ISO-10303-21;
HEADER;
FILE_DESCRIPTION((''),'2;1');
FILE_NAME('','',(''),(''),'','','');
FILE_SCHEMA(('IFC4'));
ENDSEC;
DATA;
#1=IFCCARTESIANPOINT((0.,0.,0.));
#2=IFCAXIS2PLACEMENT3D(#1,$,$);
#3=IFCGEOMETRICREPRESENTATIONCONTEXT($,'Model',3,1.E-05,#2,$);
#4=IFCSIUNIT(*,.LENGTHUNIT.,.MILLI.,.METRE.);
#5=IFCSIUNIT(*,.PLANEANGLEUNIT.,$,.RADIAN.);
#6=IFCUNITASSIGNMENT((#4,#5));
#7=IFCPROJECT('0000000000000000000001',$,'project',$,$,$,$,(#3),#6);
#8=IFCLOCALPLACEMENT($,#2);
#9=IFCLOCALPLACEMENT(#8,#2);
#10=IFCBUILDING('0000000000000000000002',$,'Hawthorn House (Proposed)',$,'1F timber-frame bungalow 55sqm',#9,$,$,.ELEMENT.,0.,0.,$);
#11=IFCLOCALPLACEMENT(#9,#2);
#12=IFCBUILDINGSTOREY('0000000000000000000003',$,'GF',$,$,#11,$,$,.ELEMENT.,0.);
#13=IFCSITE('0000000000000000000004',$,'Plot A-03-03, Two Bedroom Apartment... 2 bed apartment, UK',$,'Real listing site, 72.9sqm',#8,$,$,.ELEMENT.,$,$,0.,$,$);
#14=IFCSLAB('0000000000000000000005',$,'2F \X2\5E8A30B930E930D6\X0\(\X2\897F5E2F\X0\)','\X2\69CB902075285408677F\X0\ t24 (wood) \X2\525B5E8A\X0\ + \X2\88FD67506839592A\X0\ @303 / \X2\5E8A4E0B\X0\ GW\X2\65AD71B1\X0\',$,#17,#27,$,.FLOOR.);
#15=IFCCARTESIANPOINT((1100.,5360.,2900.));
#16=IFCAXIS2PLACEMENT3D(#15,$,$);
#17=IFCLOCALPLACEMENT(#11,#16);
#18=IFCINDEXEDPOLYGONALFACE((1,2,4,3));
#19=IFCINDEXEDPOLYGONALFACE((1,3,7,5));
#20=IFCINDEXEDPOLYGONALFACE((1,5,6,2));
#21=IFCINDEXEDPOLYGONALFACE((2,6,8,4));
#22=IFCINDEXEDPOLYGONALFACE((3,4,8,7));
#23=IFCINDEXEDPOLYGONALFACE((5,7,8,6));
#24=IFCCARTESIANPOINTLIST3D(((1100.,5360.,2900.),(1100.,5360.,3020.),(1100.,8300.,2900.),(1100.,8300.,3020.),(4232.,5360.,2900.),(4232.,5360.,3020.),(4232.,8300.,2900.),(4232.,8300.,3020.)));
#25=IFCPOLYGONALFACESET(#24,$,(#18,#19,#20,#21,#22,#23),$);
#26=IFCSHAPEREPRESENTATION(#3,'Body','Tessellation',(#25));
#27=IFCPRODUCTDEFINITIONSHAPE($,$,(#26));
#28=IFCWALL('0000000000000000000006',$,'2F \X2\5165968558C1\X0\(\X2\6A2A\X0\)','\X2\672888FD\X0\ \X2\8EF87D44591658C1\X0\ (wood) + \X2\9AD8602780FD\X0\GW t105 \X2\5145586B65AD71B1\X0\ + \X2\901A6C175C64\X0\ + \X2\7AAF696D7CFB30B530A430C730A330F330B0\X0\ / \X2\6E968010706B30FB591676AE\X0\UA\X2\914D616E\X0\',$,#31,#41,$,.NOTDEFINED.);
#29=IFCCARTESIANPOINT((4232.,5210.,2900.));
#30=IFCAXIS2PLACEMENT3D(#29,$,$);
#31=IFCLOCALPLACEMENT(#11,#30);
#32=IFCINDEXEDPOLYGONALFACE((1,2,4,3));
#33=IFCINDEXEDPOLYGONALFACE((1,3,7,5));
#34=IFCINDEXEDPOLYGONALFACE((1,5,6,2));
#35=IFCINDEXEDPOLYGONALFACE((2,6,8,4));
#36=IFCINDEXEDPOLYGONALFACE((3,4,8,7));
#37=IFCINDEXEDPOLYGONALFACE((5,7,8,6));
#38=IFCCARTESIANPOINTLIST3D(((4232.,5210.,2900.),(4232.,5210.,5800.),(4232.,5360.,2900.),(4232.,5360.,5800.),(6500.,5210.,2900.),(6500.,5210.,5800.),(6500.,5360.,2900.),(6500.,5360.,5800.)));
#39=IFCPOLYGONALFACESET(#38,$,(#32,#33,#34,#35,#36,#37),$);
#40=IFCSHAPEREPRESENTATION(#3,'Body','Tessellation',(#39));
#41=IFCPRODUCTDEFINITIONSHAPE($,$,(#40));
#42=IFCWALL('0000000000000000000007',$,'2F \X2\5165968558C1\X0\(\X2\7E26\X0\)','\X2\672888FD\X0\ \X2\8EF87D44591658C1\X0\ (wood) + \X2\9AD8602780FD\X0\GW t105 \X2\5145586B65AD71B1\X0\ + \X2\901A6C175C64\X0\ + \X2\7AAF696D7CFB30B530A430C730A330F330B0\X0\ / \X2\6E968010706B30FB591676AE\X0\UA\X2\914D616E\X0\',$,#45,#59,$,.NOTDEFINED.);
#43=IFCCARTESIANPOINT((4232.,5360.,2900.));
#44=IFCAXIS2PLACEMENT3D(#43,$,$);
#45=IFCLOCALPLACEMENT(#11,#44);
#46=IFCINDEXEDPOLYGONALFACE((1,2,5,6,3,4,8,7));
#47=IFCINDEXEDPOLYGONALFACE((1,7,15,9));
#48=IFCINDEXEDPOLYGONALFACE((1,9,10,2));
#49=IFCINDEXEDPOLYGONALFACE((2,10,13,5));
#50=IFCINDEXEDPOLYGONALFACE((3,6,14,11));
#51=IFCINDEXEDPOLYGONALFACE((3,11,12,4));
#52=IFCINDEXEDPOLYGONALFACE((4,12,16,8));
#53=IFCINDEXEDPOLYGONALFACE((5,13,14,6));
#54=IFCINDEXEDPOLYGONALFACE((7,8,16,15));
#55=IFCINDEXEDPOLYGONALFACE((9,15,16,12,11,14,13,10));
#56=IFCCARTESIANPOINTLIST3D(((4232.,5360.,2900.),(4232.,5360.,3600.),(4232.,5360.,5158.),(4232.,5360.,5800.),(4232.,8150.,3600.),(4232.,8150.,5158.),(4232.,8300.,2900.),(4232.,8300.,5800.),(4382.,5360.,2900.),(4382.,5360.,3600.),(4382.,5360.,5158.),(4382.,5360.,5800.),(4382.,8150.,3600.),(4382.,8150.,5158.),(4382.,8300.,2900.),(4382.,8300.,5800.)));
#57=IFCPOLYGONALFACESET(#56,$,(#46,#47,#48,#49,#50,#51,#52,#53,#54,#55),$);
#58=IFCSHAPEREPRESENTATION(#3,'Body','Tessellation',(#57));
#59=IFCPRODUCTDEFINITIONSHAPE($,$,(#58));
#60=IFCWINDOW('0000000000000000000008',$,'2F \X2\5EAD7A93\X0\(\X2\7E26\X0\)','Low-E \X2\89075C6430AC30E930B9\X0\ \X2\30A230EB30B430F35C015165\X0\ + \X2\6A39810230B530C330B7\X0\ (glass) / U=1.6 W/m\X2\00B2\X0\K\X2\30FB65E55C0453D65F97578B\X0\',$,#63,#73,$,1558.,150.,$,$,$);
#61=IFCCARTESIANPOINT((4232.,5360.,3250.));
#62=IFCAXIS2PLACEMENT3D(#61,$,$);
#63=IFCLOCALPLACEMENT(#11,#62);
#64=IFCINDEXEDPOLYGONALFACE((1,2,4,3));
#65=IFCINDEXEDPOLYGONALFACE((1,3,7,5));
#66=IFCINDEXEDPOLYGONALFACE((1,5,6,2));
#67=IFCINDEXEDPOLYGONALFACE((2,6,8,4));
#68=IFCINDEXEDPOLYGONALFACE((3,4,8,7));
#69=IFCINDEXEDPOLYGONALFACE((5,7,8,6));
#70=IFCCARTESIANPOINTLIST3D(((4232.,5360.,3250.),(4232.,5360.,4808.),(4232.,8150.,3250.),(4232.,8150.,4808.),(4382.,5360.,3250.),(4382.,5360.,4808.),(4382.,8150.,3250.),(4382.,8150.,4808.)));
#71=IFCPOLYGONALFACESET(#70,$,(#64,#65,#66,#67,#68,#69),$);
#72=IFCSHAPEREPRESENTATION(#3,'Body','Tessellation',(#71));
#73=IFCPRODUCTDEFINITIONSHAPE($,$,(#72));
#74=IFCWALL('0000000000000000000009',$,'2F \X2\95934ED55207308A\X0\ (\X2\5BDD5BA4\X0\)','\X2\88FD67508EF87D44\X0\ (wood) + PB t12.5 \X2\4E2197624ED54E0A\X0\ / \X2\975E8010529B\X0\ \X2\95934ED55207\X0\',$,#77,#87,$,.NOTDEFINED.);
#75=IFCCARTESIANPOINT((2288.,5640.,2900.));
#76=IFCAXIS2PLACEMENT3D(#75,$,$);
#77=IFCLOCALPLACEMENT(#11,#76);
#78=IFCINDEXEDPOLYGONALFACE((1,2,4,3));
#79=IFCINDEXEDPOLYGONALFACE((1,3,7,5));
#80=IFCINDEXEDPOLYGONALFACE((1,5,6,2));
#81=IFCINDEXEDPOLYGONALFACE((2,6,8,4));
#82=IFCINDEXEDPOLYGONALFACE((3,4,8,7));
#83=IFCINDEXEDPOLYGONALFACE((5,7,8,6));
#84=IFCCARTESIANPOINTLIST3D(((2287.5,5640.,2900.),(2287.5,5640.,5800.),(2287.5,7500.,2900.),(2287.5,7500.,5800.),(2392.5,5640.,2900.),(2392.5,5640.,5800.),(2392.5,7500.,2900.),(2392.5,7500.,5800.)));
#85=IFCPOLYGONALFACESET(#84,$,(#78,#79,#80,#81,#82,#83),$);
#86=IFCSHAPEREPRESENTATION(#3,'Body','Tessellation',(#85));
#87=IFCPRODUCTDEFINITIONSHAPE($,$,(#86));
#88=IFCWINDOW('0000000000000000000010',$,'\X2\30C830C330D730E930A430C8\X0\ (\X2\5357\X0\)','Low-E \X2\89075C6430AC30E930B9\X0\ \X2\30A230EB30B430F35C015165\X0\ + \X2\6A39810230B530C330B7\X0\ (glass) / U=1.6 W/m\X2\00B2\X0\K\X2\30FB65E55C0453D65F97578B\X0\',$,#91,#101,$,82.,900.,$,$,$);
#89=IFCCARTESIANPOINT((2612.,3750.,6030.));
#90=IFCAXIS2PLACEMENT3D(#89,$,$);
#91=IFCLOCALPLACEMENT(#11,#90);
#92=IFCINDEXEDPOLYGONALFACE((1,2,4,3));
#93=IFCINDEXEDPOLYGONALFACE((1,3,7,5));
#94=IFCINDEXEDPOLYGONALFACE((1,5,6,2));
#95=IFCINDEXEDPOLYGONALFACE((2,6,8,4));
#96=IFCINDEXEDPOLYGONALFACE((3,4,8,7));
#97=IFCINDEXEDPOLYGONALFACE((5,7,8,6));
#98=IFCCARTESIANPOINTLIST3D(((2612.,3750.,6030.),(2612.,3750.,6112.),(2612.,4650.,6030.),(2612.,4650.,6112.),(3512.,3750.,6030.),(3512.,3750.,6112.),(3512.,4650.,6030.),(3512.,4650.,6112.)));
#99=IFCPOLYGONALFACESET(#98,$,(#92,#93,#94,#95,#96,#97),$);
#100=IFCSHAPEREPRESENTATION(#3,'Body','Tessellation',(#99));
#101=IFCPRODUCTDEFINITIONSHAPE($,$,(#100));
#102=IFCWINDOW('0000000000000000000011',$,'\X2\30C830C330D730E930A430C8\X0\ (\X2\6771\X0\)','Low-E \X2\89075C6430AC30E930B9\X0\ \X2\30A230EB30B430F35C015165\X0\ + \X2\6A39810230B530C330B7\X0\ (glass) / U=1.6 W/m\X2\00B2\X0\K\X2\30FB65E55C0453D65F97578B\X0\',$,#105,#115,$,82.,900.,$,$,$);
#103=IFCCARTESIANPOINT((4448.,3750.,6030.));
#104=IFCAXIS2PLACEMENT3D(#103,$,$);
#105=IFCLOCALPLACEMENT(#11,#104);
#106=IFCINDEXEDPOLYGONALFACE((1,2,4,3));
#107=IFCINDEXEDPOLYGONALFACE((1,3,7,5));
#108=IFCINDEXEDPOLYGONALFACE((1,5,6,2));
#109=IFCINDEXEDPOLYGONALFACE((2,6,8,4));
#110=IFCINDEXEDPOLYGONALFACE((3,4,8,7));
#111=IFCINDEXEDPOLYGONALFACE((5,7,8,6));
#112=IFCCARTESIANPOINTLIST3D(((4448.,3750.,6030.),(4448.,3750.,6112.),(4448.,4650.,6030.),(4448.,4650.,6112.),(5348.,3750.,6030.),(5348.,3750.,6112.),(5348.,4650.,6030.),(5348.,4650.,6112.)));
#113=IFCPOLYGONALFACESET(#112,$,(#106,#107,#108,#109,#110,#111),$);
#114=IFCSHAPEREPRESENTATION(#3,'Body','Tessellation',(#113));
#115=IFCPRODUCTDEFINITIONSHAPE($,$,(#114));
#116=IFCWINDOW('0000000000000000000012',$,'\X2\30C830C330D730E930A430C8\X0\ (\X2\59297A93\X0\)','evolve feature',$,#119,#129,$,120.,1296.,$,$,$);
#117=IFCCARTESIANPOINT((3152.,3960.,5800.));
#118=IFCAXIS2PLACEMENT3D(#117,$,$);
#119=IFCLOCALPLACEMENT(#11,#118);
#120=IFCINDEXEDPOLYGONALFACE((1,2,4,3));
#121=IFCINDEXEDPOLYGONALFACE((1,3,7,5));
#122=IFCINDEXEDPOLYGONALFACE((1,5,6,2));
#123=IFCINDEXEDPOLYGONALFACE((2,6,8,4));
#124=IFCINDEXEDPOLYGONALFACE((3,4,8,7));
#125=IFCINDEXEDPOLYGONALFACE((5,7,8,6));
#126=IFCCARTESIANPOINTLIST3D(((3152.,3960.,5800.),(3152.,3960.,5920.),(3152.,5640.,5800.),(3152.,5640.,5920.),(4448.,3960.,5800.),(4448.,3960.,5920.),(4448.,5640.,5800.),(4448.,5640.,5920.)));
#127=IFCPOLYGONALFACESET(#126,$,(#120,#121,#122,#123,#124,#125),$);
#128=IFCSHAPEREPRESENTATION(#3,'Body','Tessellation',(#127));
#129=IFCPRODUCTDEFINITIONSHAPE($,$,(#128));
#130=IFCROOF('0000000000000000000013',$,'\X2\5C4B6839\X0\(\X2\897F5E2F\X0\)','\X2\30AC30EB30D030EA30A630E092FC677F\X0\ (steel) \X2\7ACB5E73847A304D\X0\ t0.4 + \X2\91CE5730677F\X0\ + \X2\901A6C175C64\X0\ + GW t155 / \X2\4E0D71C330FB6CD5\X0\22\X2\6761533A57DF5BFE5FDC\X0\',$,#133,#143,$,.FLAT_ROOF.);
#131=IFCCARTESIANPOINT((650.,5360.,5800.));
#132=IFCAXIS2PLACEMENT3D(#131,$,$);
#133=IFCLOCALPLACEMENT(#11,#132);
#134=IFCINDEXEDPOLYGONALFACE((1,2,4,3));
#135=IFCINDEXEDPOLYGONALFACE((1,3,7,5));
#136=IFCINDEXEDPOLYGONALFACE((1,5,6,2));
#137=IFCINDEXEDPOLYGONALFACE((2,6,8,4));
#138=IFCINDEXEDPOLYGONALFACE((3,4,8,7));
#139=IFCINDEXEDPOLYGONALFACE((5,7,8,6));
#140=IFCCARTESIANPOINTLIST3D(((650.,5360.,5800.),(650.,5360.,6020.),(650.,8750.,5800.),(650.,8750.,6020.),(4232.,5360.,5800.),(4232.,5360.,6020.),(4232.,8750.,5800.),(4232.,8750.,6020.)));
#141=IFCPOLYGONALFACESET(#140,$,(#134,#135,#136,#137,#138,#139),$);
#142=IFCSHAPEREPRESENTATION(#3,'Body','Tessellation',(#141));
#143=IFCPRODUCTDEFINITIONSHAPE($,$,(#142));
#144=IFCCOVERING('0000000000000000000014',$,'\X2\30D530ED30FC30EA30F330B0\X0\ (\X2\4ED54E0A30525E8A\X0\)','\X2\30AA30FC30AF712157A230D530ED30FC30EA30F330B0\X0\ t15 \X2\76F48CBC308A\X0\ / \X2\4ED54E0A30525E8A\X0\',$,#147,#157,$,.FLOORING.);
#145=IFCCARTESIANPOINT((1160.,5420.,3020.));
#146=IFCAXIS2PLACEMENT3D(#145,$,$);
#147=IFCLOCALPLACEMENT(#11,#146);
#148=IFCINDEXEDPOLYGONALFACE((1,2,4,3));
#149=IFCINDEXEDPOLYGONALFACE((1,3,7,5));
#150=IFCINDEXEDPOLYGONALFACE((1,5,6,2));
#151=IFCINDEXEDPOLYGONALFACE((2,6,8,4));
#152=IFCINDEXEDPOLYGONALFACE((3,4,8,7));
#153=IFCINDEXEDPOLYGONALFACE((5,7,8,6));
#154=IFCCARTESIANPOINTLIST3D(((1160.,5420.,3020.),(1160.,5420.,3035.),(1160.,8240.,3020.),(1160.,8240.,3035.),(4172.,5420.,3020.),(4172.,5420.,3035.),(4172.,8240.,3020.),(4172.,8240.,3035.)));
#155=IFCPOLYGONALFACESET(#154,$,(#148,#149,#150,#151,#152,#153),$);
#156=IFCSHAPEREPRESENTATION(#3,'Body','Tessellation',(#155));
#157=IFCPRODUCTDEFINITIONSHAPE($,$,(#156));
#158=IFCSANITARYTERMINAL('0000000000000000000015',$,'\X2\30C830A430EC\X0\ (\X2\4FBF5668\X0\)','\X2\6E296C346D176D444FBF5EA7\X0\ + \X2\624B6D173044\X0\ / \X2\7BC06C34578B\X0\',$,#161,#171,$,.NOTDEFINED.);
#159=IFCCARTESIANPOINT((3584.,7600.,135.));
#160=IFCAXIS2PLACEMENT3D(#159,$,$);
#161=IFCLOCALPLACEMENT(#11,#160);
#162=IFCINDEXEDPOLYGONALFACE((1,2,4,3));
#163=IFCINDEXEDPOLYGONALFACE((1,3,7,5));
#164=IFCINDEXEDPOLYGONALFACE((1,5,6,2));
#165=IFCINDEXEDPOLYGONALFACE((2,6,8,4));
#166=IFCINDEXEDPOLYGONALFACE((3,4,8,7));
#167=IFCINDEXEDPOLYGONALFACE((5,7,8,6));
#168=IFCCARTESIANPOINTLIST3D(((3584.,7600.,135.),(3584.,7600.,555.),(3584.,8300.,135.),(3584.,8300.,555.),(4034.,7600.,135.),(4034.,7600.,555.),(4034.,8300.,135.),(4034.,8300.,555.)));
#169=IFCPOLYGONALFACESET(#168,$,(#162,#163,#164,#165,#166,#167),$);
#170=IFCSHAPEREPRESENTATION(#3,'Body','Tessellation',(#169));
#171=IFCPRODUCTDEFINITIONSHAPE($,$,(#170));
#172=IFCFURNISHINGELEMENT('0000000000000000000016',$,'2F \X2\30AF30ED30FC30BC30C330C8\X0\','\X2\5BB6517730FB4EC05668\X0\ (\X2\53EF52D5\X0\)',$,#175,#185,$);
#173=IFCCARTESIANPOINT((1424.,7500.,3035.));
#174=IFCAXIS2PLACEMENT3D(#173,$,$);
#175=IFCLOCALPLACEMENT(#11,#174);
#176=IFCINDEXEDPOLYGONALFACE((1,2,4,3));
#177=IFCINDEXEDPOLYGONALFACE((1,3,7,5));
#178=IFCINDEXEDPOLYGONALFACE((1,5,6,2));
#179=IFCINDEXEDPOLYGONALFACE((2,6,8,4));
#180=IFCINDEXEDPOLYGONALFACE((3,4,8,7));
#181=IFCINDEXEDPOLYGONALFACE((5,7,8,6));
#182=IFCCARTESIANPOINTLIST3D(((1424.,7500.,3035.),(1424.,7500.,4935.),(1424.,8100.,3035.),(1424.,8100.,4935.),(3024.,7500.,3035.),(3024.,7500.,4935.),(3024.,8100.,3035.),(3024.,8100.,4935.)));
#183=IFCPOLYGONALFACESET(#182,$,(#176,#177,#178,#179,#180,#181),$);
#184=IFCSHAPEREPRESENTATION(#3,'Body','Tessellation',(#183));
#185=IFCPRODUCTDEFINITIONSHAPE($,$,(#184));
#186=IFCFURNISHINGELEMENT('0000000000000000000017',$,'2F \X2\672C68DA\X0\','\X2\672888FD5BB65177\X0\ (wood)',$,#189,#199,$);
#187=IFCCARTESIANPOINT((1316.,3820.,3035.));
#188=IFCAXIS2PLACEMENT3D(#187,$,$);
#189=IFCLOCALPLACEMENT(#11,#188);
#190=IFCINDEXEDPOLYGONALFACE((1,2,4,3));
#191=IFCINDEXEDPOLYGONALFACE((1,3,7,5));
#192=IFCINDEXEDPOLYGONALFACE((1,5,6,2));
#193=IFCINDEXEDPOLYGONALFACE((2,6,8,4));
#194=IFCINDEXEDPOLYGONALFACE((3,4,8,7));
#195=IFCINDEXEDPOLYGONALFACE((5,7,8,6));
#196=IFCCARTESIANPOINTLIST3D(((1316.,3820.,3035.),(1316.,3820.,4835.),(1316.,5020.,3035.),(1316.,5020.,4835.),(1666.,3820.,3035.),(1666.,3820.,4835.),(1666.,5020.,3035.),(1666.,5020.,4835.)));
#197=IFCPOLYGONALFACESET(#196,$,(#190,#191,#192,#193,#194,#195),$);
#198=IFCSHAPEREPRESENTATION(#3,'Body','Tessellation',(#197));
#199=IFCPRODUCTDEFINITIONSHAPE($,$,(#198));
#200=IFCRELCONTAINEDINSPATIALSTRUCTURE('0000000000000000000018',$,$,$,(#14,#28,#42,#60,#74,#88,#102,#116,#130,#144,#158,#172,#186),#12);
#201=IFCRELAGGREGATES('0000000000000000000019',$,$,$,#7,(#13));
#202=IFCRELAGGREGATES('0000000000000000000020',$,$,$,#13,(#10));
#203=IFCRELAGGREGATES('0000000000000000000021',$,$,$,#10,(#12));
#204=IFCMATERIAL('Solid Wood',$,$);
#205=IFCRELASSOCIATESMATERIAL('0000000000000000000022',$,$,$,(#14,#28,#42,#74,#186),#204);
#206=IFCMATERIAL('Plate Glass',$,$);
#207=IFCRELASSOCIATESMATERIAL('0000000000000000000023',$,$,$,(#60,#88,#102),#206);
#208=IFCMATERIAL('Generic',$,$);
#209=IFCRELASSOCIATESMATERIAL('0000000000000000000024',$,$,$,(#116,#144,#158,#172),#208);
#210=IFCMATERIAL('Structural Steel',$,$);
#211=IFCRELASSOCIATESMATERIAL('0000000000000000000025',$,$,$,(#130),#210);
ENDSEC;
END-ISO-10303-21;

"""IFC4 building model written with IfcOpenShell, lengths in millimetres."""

from ifc_helpers import new_model, si_unit, frame, frame_2d, origin, place, context, project, spatial, rectangle, extrude, material, element, fill, save


model = new_model("IFC4")

# Units and contexts
model_context = context("Model", 3, precision=1e-05, world=origin())
ifc_project = project(units=[si_unit("LENGTHUNIT", "METRE", prefix="MILLI"), si_unit("PLANEANGLEUNIT", "RADIAN")], contexts=[model_context])

# Site, building, storey
site_placement = place(None, origin())
site = spatial("IfcSite", under=ifc_project, at=site_placement, Name="Plot A-03-03, Two Bedroom Apartment... 2 bed apartment, UK", ObjectType="Real listing site, 72.9sqm", CompositionType="ELEMENT", RefElevation=0.0)
building_placement = place(site_placement, origin())
building = spatial("IfcBuilding", under=site, at=building_placement, Name="Hawthorn House (Proposed)", ObjectType="1F timber-frame bungalow 55sqm", CompositionType="ELEMENT", ElevationOfRefHeight=0.0, ElevationOfTerrain=0.0)
storey_placement = place(building_placement, origin())
storey = spatial("IfcBuildingStorey", under=building, at=storey_placement, Name="GF", CompositionType="ELEMENT", Elevation=0.0)

# Slab
ifc_material_1 = material(Name="Solid Wood")
slab_placement = place(storey_placement, frame((1100.0, 5360.0, 2900.0)))
element("IfcSlab", 1, at=slab_placement, inside=storey, material=ifc_material_1, Name="2F 床スラブ(西帯)", Description="構造用合板 t24 (wood) 剛床 + 製材根太 @303 / 床下 GW断熱", PredefinedType="FLOOR", context=model_context, shape_type="SweptSolid", body=[
    extrude(rectangle(XDim=3132.0, YDim=2940.0, at=frame_2d((1566.0, 1470.0))), frame((1100.0, 5360.0, 2900.0)), (0.0, 0.0, 1.0), 120.0),
])

# Shared definitions
ifc_material_2 = material(Name="Plate Glass")

# Wall
wall_1_placement = place(storey_placement, frame((4232.0, 5210.0, 2900.0)))
element("IfcWall", 2, at=wall_1_placement, inside=storey, material=ifc_material_1, Name="2F 入隅壁(横)", Description="木製 軸組外壁 (wood) + 高性能GW t105 充填断熱 + 通気層 + 窯業系サイディング / 準耐火・外皮UA配慮", PredefinedType="NOTDEFINED", context=model_context, shape_type="SweptSolid", body=[
    extrude(rectangle(XDim=2268.0, YDim=150.0, at=frame_2d((1134.0, 75.0))), frame((4232.0, 5210.0, 2900.0)), (0.0, 0.0, 1.0), 2900.0),
])

# Wall, opening, window
wall_2_placement = place(storey_placement, frame((4232.0, 5360.0, 2900.0)))
wall_2 = element("IfcWall", 3, at=wall_2_placement, inside=storey, material=ifc_material_1, Name="2F 入隅壁(縦)", Description="木製 軸組外壁 (wood) + 高性能GW t105 充填断熱 + 通気層 + 窯業系サイディング / 準耐火・外皮UA配慮", PredefinedType="NOTDEFINED", context=model_context, shape_type="SweptSolid", body=[
    extrude(rectangle(XDim=150.0, YDim=2940.0, at=frame_2d((75.0, 1470.0))), frame((4232.0, 5360.0, 2900.0)), (0.0, 0.0, 1.0), 2900.0),
])
opening_1_placement = place(storey_placement, frame((4232.0, 5360.0, 3250.0)))
opening_1 = element("IfcOpeningElement", 4, at=opening_1_placement, cuts=wall_2, PredefinedType="NOTDEFINED", context=model_context, shape_type="SweptSolid", body=[
    extrude(rectangle(XDim=150.0, YDim=2790.0, at=frame_2d((75.0, 1395.0))), frame((4232.0, 5360.0, 3250.0)), (0.0, 0.0, 1.0), 1558.0),
])
window_1_placement = place(storey_placement, frame((4232.0, 5360.0, 3250.0)))
window_1 = element("IfcWindow", 5, at=window_1_placement, inside=storey, material=ifc_material_2, Name="2F 庭窓(縦)", Description="Low-E 複層ガラス アルゴン封入 + 樹脂サッシ (glass) / U=1.6 W/m²K・日射取得型", OverallHeight=1558.0, OverallWidth=150.0, context=model_context, shape_type="SweptSolid", body=[
    extrude(rectangle(XDim=150.0, YDim=2790.0, at=frame_2d((75.0, 1395.0))), frame((4232.0, 5360.0, 3250.0)), (0.0, 0.0, 1.0), 1558.0),
])
fill(opening_1, window_1)

# Wall
wall_3_placement = place(storey_placement, frame((2288.0, 5640.0, 2900.0)))
element("IfcWall", 6, at=wall_3_placement, inside=storey, material=ifc_material_1, Name="2F 間仕切り (寝室)", Description="製材軸組 (wood) + PB t12.5 両面仕上 / 非耐力 間仕切", PredefinedType="NOTDEFINED", context=model_context, shape_type="SweptSolid", body=[
    extrude(rectangle(XDim=105.0, YDim=1860.0, at=frame_2d((52.0, 930.0))), frame((2288.0, 5640.0, 2900.0)), (0.0, 0.0, 1.0), 2900.0),
])

# Windows
window_2_placement = place(storey_placement, frame((2612.0, 3750.0, 6030.0)))
element("IfcWindow", 7, at=window_2_placement, inside=storey, material=ifc_material_2, Name="トップライト (南)", Description="Low-E 複層ガラス アルゴン封入 + 樹脂サッシ (glass) / U=1.6 W/m²K・日射取得型", OverallHeight=82.0, OverallWidth=900.0, context=model_context, shape_type="SweptSolid", body=[
    extrude(rectangle(XDim=900.0, YDim=900.0, at=frame_2d((450.0, 450.0))), frame((2612.0, 3750.0, 6030.0)), (0.0, 0.0, 1.0), 82.0),
])
window_3_placement = place(storey_placement, frame((4448.0, 3750.0, 6030.0)))
element("IfcWindow", 8, at=window_3_placement, inside=storey, material=ifc_material_2, Name="トップライト (東)", Description="Low-E 複層ガラス アルゴン封入 + 樹脂サッシ (glass) / U=1.6 W/m²K・日射取得型", OverallHeight=82.0, OverallWidth=900.0, context=model_context, shape_type="SweptSolid", body=[
    extrude(rectangle(XDim=900.0, YDim=900.0, at=frame_2d((450.0, 450.0))), frame((4448.0, 3750.0, 6030.0)), (0.0, 0.0, 1.0), 82.0),
])
ifc_material_3 = material(Name="Generic")
window_4_placement = place(storey_placement, frame((3152.0, 3960.0, 5800.0)))
element("IfcWindow", 9, at=window_4_placement, inside=storey, material=ifc_material_3, Name="トップライト (天窓)", Description="evolve feature", OverallHeight=120.0, OverallWidth=1296.0, context=model_context, shape_type="SweptSolid", body=[
    extrude(rectangle(XDim=1296.0, YDim=1680.0, at=frame_2d((648.0, 840.0))), frame((3152.0, 3960.0, 5800.0)), (0.0, 0.0, 1.0), 120.0),
])

# Roof
ifc_material_4 = material(Name="Structural Steel")
for number, where, name in (
    (10, (650.0, 5360.0, 5800.0), "屋根(西帯)"),
):
    element("IfcRoof", number, at=place(storey_placement, frame(where)), inside=storey, material=ifc_material_4, Name=name, Description="ガルバリウム鋼板 (steel) 立平葺き t0.4 + 野地板 + 通気層 + GW t155 / 不燃・法22条区域対応", PredefinedType="FLAT_ROOF", context=model_context, shape_type="SweptSolid", body=[
        extrude(rectangle(XDim=3582.0, YDim=3390.0, at=frame_2d((1791.0, 1695.0))), frame((650.0, 5360.0, 5800.0)), (0.0, 0.0, 1.0), 220.0),
    ])

# Covering
covering_placement = place(storey_placement, frame((1160.0, 5420.0, 3020.0)))
element("IfcCovering", 11, at=covering_placement, inside=storey, material=ifc_material_3, Name="フローリング (仕上げ床)", Description="オーク無垢フローリング t15 直貼り / 仕上げ床", PredefinedType="FLOORING", context=model_context, shape_type="SweptSolid", body=[
    extrude(rectangle(XDim=3012.0, YDim=2820.0, at=frame_2d((1506.0, 1410.0))), frame((1160.0, 5420.0, 3020.0)), (0.0, 0.0, 1.0), 15.0),
])

# Sanitary terminal
sanitary_terminal_placement = place(storey_placement, frame((3584.0, 7600.0, 135.0)))
element("IfcSanitaryTerminal", 12, at=sanitary_terminal_placement, inside=storey, material=ifc_material_3, Name="トイレ (便器)", Description="温水洗浄便座 + 手洗い / 節水型", PredefinedType="NOTDEFINED", context=model_context, shape_type="SweptSolid", body=[
    extrude(rectangle(XDim=450.0, YDim=700.0, at=frame_2d((225.0, 350.0))), frame((3584.0, 7600.0, 135.0)), (0.0, 0.0, 1.0), 420.0),
])

# Furnishing elements
furnishing_1_placement = place(storey_placement, frame((1424.0, 7500.0, 3035.0)))
element("IfcFurnishingElement", 13, at=furnishing_1_placement, inside=storey, material=ifc_material_3, Name="2F クローゼット", Description="家具・什器 (可動)", context=model_context, shape_type="SweptSolid", body=[
    extrude(rectangle(XDim=1600.0, YDim=600.0, at=frame_2d((800.0, 300.0))), frame((1424.0, 7500.0, 3035.0)), (0.0, 0.0, 1.0), 1900.0),
])
furnishing_2_placement = place(storey_placement, frame((1316.0, 3820.0, 3035.0)))
element("IfcFurnishingElement", 14, at=furnishing_2_placement, inside=storey, material=ifc_material_1, Name="2F 本棚", Description="木製家具 (wood)", context=model_context, shape_type="SweptSolid", body=[
    extrude(rectangle(XDim=350.0, YDim=1200.0, at=frame_2d((175.0, 600.0))), frame((1316.0, 3820.0, 3035.0)), (0.0, 0.0, 1.0), 1800.0),
])

save(model, "model.ifc")
